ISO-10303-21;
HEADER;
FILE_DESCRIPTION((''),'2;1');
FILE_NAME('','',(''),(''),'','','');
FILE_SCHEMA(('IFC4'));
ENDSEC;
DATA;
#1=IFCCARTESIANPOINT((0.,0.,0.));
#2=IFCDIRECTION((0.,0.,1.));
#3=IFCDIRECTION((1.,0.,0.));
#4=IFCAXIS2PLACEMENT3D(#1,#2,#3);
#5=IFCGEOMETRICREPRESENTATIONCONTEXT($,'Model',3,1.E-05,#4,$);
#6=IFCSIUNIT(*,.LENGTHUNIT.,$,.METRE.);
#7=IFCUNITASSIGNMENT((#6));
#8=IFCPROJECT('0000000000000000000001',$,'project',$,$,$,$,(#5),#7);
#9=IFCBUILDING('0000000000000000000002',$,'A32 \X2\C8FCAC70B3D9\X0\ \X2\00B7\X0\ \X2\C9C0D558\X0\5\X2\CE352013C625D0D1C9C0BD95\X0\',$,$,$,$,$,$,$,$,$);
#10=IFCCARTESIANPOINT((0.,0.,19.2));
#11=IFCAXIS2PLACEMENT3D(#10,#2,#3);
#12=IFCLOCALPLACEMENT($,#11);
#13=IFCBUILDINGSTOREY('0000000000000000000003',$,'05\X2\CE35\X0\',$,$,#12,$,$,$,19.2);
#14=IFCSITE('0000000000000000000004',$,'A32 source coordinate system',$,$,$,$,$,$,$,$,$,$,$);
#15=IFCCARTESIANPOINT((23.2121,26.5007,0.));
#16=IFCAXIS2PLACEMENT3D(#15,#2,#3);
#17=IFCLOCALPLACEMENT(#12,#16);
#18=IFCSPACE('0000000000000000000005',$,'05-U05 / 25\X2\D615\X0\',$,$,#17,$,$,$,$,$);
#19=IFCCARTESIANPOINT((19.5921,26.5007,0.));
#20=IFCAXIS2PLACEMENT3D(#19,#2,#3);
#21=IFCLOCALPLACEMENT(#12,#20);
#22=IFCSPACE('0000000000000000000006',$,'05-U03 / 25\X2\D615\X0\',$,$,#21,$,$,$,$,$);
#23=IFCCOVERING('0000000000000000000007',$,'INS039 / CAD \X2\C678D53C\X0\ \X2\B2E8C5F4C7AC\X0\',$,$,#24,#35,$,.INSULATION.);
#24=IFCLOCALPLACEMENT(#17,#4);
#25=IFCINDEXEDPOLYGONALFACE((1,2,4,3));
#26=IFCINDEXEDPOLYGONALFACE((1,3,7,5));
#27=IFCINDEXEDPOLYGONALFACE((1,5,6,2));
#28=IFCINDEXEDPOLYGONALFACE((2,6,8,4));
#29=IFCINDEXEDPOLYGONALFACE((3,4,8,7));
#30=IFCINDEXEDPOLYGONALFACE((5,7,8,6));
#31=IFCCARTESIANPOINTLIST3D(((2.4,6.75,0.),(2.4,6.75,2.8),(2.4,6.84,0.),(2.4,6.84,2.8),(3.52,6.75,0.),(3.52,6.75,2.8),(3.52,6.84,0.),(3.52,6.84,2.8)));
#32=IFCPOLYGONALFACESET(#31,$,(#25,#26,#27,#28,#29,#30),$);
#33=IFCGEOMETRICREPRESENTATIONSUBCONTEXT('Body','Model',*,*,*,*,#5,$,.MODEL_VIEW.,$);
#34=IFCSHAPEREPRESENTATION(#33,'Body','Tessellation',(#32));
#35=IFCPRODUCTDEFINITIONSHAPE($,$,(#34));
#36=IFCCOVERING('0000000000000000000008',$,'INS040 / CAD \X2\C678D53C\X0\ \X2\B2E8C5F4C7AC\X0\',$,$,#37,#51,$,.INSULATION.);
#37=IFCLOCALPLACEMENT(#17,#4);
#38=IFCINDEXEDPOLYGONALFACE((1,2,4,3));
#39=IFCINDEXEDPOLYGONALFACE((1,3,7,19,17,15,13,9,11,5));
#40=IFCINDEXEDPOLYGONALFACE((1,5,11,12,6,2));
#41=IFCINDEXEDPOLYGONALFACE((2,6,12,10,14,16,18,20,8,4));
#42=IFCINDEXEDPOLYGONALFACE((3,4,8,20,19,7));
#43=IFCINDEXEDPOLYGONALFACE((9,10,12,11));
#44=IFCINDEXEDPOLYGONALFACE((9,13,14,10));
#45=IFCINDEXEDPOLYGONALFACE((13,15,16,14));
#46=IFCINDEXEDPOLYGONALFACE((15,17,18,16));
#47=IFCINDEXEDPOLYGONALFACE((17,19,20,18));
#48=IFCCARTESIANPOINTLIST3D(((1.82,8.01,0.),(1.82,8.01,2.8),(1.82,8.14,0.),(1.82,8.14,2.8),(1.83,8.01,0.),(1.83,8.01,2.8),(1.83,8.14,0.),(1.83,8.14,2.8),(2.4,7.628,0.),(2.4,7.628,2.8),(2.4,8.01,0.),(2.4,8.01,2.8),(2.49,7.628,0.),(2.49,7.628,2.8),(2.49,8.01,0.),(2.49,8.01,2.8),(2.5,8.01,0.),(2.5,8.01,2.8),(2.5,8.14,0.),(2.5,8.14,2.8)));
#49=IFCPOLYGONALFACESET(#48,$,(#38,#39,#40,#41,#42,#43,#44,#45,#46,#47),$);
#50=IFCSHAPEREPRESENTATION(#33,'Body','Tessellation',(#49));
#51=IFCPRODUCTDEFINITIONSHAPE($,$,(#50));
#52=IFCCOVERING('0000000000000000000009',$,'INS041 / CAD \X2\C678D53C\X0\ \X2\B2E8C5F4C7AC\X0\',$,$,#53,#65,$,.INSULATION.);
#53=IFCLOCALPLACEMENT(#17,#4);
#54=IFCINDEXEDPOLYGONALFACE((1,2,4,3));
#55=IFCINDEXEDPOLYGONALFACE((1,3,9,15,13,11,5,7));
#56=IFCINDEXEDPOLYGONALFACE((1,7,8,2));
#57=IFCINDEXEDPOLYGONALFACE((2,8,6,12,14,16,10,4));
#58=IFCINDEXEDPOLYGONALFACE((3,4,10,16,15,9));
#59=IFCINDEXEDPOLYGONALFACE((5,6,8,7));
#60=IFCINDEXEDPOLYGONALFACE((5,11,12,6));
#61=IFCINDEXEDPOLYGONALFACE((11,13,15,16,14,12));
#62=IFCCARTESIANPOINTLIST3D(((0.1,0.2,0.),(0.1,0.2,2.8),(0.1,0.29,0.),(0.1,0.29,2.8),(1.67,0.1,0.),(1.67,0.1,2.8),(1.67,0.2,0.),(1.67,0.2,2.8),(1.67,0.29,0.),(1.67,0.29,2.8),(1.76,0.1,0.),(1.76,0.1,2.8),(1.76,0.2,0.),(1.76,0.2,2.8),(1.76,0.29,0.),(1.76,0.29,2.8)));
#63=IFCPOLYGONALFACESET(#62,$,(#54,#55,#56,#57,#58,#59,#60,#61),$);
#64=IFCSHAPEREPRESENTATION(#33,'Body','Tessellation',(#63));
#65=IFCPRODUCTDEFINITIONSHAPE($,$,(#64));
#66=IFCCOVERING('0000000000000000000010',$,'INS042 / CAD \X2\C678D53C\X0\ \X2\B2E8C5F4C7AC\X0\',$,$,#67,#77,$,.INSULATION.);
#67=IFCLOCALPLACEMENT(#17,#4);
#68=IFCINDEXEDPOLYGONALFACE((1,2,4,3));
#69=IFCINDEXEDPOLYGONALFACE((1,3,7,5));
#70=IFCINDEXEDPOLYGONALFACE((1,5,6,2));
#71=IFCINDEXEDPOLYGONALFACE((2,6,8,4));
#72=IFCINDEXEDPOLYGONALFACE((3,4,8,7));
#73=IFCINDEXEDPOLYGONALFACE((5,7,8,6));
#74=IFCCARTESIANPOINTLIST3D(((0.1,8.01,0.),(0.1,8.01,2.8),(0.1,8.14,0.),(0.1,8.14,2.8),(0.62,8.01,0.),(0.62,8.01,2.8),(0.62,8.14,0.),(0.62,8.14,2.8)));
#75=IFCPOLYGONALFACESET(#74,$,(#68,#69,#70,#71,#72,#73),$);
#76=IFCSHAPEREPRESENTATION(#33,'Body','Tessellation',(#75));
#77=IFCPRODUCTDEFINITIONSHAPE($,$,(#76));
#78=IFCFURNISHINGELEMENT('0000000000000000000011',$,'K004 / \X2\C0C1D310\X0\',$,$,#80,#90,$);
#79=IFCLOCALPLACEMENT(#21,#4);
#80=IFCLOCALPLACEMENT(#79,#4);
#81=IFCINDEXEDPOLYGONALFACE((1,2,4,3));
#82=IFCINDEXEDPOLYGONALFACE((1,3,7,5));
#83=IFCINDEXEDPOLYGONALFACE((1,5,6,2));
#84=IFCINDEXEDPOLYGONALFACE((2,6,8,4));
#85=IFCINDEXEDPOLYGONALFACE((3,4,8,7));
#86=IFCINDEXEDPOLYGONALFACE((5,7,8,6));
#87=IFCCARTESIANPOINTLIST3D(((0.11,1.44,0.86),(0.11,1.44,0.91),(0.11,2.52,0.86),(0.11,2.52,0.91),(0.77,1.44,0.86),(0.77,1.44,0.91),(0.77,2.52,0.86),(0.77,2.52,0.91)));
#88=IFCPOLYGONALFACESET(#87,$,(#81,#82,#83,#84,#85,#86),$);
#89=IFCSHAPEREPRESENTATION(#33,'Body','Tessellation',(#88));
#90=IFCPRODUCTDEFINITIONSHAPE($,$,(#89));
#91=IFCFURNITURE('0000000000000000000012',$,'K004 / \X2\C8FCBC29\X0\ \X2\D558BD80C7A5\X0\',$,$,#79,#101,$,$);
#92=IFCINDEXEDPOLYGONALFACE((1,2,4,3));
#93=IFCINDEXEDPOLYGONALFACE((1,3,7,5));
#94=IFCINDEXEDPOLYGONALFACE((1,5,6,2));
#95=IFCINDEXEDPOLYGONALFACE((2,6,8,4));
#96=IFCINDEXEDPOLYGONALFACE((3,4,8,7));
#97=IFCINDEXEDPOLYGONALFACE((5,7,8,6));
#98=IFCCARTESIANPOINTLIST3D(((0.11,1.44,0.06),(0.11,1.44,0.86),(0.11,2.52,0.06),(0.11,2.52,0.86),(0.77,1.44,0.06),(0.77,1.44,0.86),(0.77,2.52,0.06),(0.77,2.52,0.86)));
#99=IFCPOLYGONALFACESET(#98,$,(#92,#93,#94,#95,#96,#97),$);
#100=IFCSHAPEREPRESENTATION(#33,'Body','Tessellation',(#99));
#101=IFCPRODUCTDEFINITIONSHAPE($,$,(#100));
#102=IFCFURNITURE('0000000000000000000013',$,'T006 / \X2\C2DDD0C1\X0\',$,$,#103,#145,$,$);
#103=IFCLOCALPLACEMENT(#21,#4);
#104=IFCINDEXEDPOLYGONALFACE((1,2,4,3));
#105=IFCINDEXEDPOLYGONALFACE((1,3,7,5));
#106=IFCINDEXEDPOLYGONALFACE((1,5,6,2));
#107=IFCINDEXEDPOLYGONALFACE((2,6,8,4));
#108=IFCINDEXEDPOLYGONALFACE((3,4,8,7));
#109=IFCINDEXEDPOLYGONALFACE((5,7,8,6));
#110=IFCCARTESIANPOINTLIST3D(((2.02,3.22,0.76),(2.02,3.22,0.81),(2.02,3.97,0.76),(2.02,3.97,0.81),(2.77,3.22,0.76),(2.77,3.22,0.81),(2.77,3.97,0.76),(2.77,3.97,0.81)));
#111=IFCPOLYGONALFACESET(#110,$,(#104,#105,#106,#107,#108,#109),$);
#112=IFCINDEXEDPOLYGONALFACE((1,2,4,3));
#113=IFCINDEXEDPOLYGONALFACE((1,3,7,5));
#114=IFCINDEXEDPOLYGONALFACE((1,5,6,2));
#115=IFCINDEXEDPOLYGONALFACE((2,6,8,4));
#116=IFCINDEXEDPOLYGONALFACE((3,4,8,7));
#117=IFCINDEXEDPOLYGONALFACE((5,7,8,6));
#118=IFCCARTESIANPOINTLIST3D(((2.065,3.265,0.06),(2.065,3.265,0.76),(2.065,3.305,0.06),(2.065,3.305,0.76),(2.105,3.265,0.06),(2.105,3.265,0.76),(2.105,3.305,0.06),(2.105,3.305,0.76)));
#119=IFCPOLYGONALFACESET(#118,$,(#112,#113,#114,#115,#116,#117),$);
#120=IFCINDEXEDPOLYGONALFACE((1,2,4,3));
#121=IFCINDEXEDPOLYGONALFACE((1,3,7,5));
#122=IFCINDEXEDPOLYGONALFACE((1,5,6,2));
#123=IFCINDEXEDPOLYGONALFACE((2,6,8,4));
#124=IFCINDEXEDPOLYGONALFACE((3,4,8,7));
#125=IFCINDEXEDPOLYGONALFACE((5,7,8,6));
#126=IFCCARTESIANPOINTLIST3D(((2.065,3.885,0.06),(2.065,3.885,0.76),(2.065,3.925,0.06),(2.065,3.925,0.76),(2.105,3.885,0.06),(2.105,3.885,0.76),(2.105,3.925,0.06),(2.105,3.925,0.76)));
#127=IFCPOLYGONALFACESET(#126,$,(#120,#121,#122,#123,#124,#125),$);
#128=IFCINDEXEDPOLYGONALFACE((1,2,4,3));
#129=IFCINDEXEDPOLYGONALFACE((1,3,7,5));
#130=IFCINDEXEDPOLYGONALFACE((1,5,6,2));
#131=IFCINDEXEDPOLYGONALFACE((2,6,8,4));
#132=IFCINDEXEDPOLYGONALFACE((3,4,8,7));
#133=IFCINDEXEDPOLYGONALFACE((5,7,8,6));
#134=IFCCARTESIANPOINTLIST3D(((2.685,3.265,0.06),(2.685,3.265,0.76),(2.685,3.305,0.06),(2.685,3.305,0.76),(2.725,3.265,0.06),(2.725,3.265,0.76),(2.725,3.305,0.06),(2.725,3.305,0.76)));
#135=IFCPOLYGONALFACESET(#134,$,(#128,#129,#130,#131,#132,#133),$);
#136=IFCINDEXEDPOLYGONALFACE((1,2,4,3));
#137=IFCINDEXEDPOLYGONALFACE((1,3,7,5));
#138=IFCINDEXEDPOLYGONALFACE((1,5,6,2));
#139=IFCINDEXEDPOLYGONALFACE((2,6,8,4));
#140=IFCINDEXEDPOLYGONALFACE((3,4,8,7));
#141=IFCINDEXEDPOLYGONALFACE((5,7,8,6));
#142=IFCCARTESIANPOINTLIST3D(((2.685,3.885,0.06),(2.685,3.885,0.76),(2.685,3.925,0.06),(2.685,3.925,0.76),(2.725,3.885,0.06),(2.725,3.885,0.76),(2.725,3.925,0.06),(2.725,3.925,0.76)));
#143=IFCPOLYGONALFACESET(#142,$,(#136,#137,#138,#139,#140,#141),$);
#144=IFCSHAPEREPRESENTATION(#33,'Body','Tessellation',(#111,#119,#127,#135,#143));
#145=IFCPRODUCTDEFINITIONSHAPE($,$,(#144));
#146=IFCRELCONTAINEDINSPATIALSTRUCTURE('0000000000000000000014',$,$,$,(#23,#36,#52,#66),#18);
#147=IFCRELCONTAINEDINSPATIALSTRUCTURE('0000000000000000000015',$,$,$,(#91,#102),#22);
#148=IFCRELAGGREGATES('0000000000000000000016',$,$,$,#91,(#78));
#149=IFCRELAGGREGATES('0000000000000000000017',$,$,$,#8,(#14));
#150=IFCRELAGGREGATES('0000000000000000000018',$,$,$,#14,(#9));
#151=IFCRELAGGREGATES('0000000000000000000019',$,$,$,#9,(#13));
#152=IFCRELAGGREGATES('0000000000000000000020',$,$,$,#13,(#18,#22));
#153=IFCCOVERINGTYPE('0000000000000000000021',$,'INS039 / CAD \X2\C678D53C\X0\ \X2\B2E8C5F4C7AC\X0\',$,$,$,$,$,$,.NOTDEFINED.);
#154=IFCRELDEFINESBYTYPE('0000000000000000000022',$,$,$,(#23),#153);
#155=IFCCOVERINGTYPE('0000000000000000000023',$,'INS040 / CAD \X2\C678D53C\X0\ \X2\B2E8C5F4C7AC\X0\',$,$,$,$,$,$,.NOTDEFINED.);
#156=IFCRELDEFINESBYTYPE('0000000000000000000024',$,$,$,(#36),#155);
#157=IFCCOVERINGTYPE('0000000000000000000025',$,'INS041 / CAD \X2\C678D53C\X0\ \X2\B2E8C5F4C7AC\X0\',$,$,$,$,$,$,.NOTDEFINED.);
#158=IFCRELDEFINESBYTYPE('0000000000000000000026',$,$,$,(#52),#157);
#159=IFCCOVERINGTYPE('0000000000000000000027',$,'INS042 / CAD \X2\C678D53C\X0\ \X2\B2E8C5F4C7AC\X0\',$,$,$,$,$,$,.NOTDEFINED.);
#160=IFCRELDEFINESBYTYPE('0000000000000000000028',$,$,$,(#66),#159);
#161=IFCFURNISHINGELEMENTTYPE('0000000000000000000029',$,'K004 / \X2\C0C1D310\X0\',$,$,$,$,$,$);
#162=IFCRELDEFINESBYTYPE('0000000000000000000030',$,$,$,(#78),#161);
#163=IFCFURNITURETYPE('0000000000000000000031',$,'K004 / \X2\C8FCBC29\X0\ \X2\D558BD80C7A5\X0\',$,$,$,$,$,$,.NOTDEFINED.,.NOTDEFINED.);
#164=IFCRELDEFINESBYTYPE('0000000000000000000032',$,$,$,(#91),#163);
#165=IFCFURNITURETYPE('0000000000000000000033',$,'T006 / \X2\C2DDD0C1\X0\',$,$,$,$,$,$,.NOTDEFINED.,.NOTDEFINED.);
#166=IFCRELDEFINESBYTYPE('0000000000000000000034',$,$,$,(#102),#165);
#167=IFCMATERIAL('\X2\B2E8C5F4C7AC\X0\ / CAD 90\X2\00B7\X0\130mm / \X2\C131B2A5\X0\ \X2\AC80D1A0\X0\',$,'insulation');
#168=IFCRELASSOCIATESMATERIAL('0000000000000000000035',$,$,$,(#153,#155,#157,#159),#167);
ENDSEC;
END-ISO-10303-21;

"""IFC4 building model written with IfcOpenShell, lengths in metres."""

from ifc_helpers import new_model, si_unit, frame, origin, origin_with_axes, place, context, subcontext, project, spatial, polyline, outline, extrude, source, transform, mapped, material, type_object, type_shapes, element, aggregate, save


model = new_model("IFC4")

# Units and contexts
model_context = context("Model", 3, precision=1e-05, world=origin_with_axes())
body_context = subcontext(model_context, "Body", "Model", "MODEL_VIEW")
ifc_project = project(units=[si_unit("LENGTHUNIT", "METRE")], contexts=[model_context])

# Site, building, storey, space
storey_placement = place(None, frame((0.0, 0.0, 19.2), z_axis=(0.0, 0.0, 1.0), x_axis=(1.0, 0.0, 0.0)))
space_1_placement = place(storey_placement, frame((23.2121, 26.5007, 0.0), z_axis=(0.0, 0.0, 1.0), x_axis=(1.0, 0.0, 0.0)))
site = spatial("IfcSite", under=ifc_project, Name="A32 source coordinate system")
building = spatial("IfcBuilding", under=site, Name="A32 주거동 · 지하5층–옥탑지붕")
storey = spatial("IfcBuildingStorey", under=building, at=storey_placement, Name="05층", Elevation=19.2)
space_1 = spatial("IfcSpace", under=storey, at=space_1_placement, Name="05-U05 / 25형")

# Shared definitions
space_2_placement = place(storey_placement, frame((19.5921, 26.5007, 0.0), z_axis=(0.0, 0.0, 1.0), x_axis=(1.0, 0.0, 0.0)))
space_2 = spatial("IfcSpace", under=storey, at=space_2_placement, Name="05-U03 / 25형")

# Coverings
ifc_material = material(Name="단열재 / CAD 90·130mm / 성능 검토", Category="insulation")
covering_type_1 = type_object("IfcCoveringType", Name="INS039 / CAD 외피 단열재", PredefinedType="NOTDEFINED", material=ifc_material)
shared_shape_1 = source(origin(), body_context, "Body", "SweptSolid", [
    extrude(outline(polyline([(2.4, 6.75), (2.4, 6.84), (3.52, 6.84), (3.52, 6.75), (2.4, 6.75)])), origin(), (0.0, 0.0, 1.0), 2.8),
])
type_shapes(covering_type_1, [shared_shape_1])
covering_1_placement = place(space_1_placement, origin_with_axes())
element("IfcCovering", 1, at=covering_1_placement, inside=space_1, type_object=covering_type_1, Name="INS039 / CAD 외피 단열재", PredefinedType="INSULATION", context=body_context, shape_type="MappedRepresentation", body=[
    mapped(shared_shape_1, transform((0.0, 0.0, 0.0), scale=1.0)),
])
covering_type_2 = type_object("IfcCoveringType", Name="INS040 / CAD 외피 단열재", PredefinedType="NOTDEFINED", material=ifc_material)
shared_shape_2 = source(origin(), body_context, "Body", "SweptSolid", [
    extrude(outline(polyline([(2.4, 7.628), (2.4, 8.01), (1.83, 8.01), (1.82, 8.01), (1.82, 8.14), (1.83, 8.14), (2.5, 8.14), (2.5, 8.01), (2.49, 8.01), (2.49, 7.628), (2.4, 7.628)])), origin(), (0.0, 0.0, 1.0), 2.8),
])
type_shapes(covering_type_2, [shared_shape_2])
covering_2_placement = place(space_1_placement, origin_with_axes())
element("IfcCovering", 2, at=covering_2_placement, inside=space_1, type_object=covering_type_2, Name="INS040 / CAD 외피 단열재", PredefinedType="INSULATION", context=body_context, shape_type="MappedRepresentation", body=[
    mapped(shared_shape_2, transform((0.0, 0.0, 0.0), scale=1.0)),
])
covering_type_3 = type_object("IfcCoveringType", Name="INS041 / CAD 외피 단열재", PredefinedType="NOTDEFINED", material=ifc_material)
shared_shape_3 = source(origin(), body_context, "Body", "SweptSolid", [
    extrude(outline(polyline([(1.67, 0.2), (0.1, 0.2), (0.1, 0.29), (1.67, 0.29), (1.76, 0.29), (1.76, 0.2), (1.76, 0.1), (1.67, 0.1), (1.67, 0.2)])), origin(), (0.0, 0.0, 1.0), 2.8),
])
type_shapes(covering_type_3, [shared_shape_3])
covering_3_placement = place(space_1_placement, origin_with_axes())
element("IfcCovering", 3, at=covering_3_placement, inside=space_1, type_object=covering_type_3, Name="INS041 / CAD 외피 단열재", PredefinedType="INSULATION", context=body_context, shape_type="MappedRepresentation", body=[
    mapped(shared_shape_3, transform((0.0, 0.0, 0.0), scale=1.0)),
])
covering_type_4 = type_object("IfcCoveringType", Name="INS042 / CAD 외피 단열재", PredefinedType="NOTDEFINED", material=ifc_material)
shared_shape_4 = source(origin(), body_context, "Body", "SweptSolid", [
    extrude(outline(polyline([(0.62, 8.14), (0.62, 8.01), (0.1, 8.01), (0.1, 8.14), (0.62, 8.14)])), origin(), (0.0, 0.0, 1.0), 2.8),
])
type_shapes(covering_type_4, [shared_shape_4])
covering_4_placement = place(space_1_placement, origin_with_axes())
element("IfcCovering", 4, at=covering_4_placement, inside=space_1, type_object=covering_type_4, Name="INS042 / CAD 외피 단열재", PredefinedType="INSULATION", context=body_context, shape_type="MappedRepresentation", body=[
    mapped(shared_shape_4, transform((0.0, 0.0, 0.0), scale=1.0)),
])

# Furnishing element
furnishing_element_type_1 = type_object("IfcFurnishingElementType", Name="K004 / 상판")
shared_shape_5 = source(origin(), body_context, "Body", "SweptSolid", [
    extrude(outline(polyline([(0.77, 2.52), (0.77, 1.44), (0.11, 1.44), (0.11, 2.52), (0.77, 2.52)])), frame((0.0, 0.0, 0.86)), (0.0, 0.0, 1.0), 0.05),
])
type_shapes(furnishing_element_type_1, [shared_shape_5])
furniture_1_placement = place(space_2_placement, origin_with_axes())
furnishing_1_placement = place(furniture_1_placement, origin_with_axes())
furnishing_1 = element("IfcFurnishingElement", 5, at=furnishing_1_placement, type_object=furnishing_element_type_1, Name="K004 / 상판", context=body_context, shape_type="MappedRepresentation", body=[
    mapped(shared_shape_5, transform((0.0, 0.0, 0.0), scale=1.0)),
])

# Furniture
furniture_type_1 = type_object("IfcFurnitureType", Name="K004 / 주방 하부장", AssemblyPlace="NOTDEFINED", PredefinedType="NOTDEFINED")
shared_shape_6 = source(origin(), body_context, "Body", "SweptSolid", [
    extrude(outline(polyline([(0.11, 2.52), (0.77, 2.52), (0.77, 1.44), (0.11, 1.44), (0.11, 2.52)])), frame((0.0, 0.0, 0.06)), (0.0, 0.0, 1.0), 0.8),
])
type_shapes(furniture_type_1, [shared_shape_6])
furniture_1 = element("IfcFurniture", 6, at=furniture_1_placement, inside=space_2, type_object=furniture_type_1, Name="K004 / 주방 하부장", context=body_context, shape_type="MappedRepresentation", body=[
    mapped(shared_shape_6, transform((0.0, 0.0, 0.0), scale=1.0)),
])
aggregate(furniture_1, [furnishing_1])
furniture_type_2 = type_object("IfcFurnitureType", Name="T006 / 식탁", AssemblyPlace="NOTDEFINED", PredefinedType="NOTDEFINED")
shared_shape_7 = source(origin(), body_context, "Body", "SweptSolid", [
    extrude(outline(polyline([(2.77, 3.22), (2.02, 3.22), (2.02, 3.97), (2.77, 3.97), (2.77, 3.22)])), frame((0.0, 0.0, 0.76)), (0.0, 0.0, 1.0), 0.05),
    extrude(outline(polyline([(2.065, 3.265), (2.065, 3.305), (2.105, 3.305), (2.105, 3.265), (2.065, 3.265)])), frame((0.0, 0.0, 0.06)), (0.0, 0.0, 1.0), 0.7),
    extrude(outline(polyline([(2.065, 3.885), (2.065, 3.925), (2.105, 3.925), (2.105, 3.885), (2.065, 3.885)])), frame((0.0, 0.0, 0.06)), (0.0, 0.0, 1.0), 0.7),
    extrude(outline(polyline([(2.685, 3.265), (2.685, 3.305), (2.725, 3.305), (2.725, 3.265), (2.685, 3.265)])), frame((0.0, 0.0, 0.06)), (0.0, 0.0, 1.0), 0.7),
    extrude(outline(polyline([(2.685, 3.885), (2.685, 3.925), (2.725, 3.925), (2.725, 3.885), (2.685, 3.885)])), frame((0.0, 0.0, 0.06)), (0.0, 0.0, 1.0), 0.7),
])
type_shapes(furniture_type_2, [shared_shape_7])
furniture_2_placement = place(space_2_placement, origin_with_axes())
element("IfcFurniture", 7, at=furniture_2_placement, inside=space_2, type_object=furniture_type_2, Name="T006 / 식탁", context=body_context, shape_type="MappedRepresentation", body=[
    mapped(shared_shape_7, transform((0.0, 0.0, 0.0), scale=1.0)),
])

save(model, "model.ifc")
